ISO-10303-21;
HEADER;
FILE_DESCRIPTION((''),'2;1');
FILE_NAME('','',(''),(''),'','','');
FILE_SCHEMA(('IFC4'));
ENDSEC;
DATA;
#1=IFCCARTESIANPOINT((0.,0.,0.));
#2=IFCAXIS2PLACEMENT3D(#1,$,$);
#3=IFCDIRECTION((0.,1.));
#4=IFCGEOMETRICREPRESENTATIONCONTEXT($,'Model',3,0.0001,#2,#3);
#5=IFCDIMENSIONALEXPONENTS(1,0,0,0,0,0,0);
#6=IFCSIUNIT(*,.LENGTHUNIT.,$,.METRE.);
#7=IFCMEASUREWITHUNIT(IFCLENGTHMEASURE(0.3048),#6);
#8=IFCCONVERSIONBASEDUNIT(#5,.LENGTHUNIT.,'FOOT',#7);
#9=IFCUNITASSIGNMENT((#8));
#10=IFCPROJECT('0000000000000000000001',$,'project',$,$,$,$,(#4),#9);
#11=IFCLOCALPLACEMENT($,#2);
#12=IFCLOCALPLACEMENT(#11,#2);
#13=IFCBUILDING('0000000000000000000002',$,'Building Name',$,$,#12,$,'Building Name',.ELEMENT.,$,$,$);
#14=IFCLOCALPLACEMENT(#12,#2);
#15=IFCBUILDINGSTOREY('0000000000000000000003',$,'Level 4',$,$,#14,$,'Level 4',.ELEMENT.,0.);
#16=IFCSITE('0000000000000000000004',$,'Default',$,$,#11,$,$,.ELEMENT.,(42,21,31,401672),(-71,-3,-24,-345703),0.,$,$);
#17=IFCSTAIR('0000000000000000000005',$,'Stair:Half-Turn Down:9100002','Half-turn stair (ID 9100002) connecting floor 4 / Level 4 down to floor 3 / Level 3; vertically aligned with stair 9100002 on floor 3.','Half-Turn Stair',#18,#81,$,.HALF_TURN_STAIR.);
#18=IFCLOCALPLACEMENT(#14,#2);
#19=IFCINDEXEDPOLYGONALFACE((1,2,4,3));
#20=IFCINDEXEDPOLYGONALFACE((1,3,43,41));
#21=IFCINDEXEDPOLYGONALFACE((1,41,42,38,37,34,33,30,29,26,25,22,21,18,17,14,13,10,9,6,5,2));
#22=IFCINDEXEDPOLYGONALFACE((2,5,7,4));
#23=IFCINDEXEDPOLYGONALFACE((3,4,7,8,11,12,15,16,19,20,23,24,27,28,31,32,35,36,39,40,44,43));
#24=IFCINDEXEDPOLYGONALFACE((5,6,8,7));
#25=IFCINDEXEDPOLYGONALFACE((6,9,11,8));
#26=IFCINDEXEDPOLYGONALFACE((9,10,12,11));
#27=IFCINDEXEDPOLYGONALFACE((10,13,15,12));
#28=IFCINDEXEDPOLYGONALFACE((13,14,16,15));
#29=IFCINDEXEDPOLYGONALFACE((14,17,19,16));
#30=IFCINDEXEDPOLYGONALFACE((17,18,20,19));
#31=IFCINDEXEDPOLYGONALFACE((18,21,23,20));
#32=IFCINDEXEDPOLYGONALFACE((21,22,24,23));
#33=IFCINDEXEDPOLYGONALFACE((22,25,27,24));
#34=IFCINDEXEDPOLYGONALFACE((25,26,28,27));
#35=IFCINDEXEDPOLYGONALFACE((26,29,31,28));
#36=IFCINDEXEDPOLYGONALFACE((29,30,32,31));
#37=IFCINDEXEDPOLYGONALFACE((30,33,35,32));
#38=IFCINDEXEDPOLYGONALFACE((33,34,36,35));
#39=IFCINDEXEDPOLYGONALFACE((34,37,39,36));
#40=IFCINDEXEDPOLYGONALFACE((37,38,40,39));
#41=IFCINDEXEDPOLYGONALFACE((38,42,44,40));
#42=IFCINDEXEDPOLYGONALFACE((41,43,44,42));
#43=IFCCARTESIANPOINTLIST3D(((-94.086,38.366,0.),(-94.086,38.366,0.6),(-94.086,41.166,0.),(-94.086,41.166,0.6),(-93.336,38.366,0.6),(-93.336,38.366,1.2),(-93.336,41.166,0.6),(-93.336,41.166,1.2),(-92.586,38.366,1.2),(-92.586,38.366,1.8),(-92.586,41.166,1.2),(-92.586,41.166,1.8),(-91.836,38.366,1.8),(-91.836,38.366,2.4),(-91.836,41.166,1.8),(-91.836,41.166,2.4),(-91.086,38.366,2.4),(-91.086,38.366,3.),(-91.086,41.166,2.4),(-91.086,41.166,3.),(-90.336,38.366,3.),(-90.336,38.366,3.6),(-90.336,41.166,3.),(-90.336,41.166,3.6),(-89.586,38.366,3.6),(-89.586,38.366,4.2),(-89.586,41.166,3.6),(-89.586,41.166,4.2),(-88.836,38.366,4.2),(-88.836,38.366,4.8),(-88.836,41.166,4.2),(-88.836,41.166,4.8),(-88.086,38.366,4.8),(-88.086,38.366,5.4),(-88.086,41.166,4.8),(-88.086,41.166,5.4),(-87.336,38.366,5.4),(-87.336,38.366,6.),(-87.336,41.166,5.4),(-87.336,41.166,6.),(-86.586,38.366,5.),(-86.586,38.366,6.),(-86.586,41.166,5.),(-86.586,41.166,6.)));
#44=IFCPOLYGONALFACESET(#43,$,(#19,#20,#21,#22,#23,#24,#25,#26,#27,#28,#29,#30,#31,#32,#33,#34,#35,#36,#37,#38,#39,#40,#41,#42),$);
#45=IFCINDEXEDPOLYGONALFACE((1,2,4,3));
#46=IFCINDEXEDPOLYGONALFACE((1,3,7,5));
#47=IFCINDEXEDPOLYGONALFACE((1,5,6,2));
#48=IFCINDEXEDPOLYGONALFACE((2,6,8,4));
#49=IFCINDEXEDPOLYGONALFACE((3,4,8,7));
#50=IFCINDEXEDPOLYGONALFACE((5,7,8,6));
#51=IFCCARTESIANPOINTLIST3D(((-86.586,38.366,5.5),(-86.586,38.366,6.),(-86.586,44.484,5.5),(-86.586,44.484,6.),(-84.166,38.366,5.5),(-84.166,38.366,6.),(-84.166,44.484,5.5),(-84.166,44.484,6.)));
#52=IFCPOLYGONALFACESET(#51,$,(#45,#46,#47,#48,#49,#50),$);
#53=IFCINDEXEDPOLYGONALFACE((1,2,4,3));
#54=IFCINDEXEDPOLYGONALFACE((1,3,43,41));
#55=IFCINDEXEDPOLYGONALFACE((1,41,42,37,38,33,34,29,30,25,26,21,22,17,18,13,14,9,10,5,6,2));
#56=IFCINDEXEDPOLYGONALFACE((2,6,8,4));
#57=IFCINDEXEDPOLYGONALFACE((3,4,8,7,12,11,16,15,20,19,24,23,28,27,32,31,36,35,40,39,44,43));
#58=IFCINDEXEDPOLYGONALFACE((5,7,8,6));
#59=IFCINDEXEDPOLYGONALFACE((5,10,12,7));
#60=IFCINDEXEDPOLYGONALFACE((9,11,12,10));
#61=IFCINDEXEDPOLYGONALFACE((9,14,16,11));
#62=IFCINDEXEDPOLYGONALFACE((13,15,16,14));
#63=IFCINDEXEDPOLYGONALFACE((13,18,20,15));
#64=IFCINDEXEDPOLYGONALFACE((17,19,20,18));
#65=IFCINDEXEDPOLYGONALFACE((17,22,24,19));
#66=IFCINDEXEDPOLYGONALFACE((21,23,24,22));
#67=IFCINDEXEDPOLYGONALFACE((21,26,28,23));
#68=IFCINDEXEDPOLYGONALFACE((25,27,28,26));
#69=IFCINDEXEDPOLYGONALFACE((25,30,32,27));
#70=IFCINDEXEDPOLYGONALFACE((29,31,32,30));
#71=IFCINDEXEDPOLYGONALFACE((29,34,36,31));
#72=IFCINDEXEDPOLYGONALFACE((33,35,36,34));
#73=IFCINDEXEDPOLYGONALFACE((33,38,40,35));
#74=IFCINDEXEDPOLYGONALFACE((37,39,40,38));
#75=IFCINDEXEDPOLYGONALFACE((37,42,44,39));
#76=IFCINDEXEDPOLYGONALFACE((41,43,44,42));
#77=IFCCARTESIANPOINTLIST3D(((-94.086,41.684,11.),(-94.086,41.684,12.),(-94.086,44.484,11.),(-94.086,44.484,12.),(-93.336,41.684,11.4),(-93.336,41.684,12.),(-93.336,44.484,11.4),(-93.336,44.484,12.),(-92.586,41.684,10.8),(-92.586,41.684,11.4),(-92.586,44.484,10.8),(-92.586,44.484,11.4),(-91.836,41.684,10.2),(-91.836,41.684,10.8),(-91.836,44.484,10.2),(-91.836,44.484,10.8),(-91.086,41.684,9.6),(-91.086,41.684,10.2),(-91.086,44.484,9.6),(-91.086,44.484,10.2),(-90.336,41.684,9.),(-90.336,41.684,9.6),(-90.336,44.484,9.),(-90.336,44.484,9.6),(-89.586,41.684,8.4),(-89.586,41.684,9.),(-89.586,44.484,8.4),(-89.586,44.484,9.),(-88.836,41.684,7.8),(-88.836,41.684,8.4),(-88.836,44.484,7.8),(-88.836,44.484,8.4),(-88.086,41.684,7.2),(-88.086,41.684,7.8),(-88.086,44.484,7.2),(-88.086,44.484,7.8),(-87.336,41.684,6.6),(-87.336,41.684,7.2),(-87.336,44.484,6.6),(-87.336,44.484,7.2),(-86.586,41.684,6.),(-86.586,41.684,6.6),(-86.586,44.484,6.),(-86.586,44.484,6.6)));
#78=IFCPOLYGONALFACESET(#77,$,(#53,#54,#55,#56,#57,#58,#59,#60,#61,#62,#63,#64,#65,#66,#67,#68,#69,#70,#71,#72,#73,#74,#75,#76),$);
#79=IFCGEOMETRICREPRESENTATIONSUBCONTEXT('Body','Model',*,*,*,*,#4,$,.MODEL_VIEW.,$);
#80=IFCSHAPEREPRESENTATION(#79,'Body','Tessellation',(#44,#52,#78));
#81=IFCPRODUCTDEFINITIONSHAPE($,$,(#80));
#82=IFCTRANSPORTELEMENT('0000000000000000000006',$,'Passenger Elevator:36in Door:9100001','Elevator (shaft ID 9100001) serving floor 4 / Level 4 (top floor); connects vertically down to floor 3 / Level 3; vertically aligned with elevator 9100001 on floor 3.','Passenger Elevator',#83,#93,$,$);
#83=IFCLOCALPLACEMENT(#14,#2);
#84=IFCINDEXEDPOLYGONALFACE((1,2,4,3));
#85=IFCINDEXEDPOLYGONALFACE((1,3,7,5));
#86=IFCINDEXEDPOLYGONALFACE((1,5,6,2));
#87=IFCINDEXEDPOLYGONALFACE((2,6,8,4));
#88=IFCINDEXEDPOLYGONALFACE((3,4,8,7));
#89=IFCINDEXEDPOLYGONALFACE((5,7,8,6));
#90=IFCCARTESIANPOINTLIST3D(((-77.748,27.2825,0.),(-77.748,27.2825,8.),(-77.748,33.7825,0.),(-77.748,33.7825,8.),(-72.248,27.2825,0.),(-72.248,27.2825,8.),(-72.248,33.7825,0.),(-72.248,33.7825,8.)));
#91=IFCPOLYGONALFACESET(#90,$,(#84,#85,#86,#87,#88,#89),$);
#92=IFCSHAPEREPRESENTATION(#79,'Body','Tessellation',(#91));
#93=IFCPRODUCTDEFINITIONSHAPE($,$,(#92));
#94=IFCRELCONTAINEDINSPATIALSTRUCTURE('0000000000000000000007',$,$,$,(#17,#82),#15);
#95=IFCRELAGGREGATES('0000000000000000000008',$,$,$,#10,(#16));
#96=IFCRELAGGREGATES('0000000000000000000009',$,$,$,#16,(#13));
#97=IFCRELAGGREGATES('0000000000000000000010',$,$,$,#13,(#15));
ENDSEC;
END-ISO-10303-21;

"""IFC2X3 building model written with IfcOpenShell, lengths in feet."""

from ifc_helpers import new_model, entity, si_unit, converted_unit, direction, frame, frame_2d, origin, place, context, subcontext, project, spatial, polyline, rectangle, outline, extrude, element, save


model = new_model("IFC2X3")

# Units and contexts
model_context = context("Model", 3, precision=0.0001, world=origin(), true_north=direction((0.0, 1.0)))
body_context = subcontext(model_context, "Body", "Model", "MODEL_VIEW")
ifc_project = project(units=[converted_unit("LENGTHUNIT", "FOOT", entity("IfcLengthMeasure", 0.3048), si_unit("LENGTHUNIT", "METRE"), dimensions=[1, 0, 0, 0, 0, 0, 0])], contexts=[model_context])

# Site, building, storey
site_placement = place(None, origin())
site = spatial("IfcSite", under=ifc_project, at=site_placement, Name="Default", CompositionType="ELEMENT", RefLatitude=(42, 21, 31, 401672), RefLongitude=(-71, -3, -24, -345703), RefElevation=0.0)
building_placement = place(site_placement, origin())
building = spatial("IfcBuilding", under=site, at=building_placement, Name="Building Name", LongName="Building Name", CompositionType="ELEMENT")
storey_placement = place(building_placement, origin())
storey = spatial("IfcBuildingStorey", under=building, at=storey_placement, Name="Level 4", LongName="Level 4", CompositionType="ELEMENT", Elevation=0.0)

# Stair
stair_placement = place(storey_placement, frame((-94.086, 38.366, 0.0), z_axis=(0.0, 0.0, 1.0), x_axis=(1.0, 0.0, 0.0)))
element("IfcStair", 1, at=stair_placement, inside=storey, Name="Stair:Half-Turn Down:9100002", Description="Half-turn stair (ID 9100002) connecting floor 4 / Level 4 down to floor 3 / Level 3; vertically aligned with stair 9100002 on floor 3.", ObjectType="Half-Turn Stair", ShapeType="HALF_TURN_STAIR", context=body_context, shape_type="SweptSolid", body=[
    extrude(outline(polyline([(0.0, 0.0), (0.0, 0.6), (0.75, 0.6), (0.75, 1.2), (1.5, 1.2), (1.5, 1.8), (2.25, 1.8), (2.25, 2.4), (3.0, 2.4), (3.0, 3.0), (3.75, 3.0), (3.75, 3.6), (4.5, 3.6), (4.5, 4.2), (5.25, 4.2), (5.25, 4.8), (6.0, 4.8), (6.0, 5.4), (6.75, 5.4), (6.75, 6.0), (7.5, 6.0), (7.5, 5.0), (0.0, 0.0)])), frame((0.0, 2.8, 0.0), z_axis=(0.0, -1.0, 0.0), x_axis=(1.0, 0.0, 0.0)), (0.0, 0.0, 1.0), 2.8),
    extrude(rectangle(XDim=2.42, YDim=6.118, at=frame_2d((8.71, 3.059))), frame((0.0, 0.0, 5.5)), (0.0, 0.0, 1.0), 0.5),
    extrude(outline(polyline([(0.0, 0.0), (0.0, 0.6), (0.75, 0.6), (0.75, 1.2), (1.5, 1.2), (1.5, 1.8), (2.25, 1.8), (2.25, 2.4), (3.0, 2.4), (3.0, 3.0), (3.75, 3.0), (3.75, 3.6), (4.5, 3.6), (4.5, 4.2), (5.25, 4.2), (5.25, 4.8), (6.0, 4.8), (6.0, 5.4), (6.75, 5.4), (6.75, 6.0), (7.5, 6.0), (7.5, 5.0), (0.0, 0.0)])), frame((7.5, 3.318, 6.0), z_axis=(0.0, 1.0, 0.0), x_axis=(-1.0, 0.0, 0.0)), (0.0, 0.0, 1.0), 2.8),
])

# Transport element
transport_element_placement = place(storey_placement, frame((-77.748, 30.5325, 0.0), z_axis=(0.0, 0.0, 1.0), x_axis=(1.0, 0.0, 0.0)))
element("IfcTransportElement", 2, at=transport_element_placement, inside=storey, Name="Passenger Elevator:36in Door:9100001", Description="Elevator (shaft ID 9100001) serving floor 4 / Level 4 (top floor); connects vertically down to floor 3 / Level 3; vertically aligned with elevator 9100001 on floor 3.", ObjectType="Passenger Elevator", OperationType="ELEVATOR", context=body_context, shape_type="SweptSolid", body=[
    extrude(rectangle(XDim=5.5, YDim=6.5, at=frame_2d((2.75, 0.0))), origin(), (0.0, 0.0, 1.0), 8.0),
])

save(model, "model.ifc")
